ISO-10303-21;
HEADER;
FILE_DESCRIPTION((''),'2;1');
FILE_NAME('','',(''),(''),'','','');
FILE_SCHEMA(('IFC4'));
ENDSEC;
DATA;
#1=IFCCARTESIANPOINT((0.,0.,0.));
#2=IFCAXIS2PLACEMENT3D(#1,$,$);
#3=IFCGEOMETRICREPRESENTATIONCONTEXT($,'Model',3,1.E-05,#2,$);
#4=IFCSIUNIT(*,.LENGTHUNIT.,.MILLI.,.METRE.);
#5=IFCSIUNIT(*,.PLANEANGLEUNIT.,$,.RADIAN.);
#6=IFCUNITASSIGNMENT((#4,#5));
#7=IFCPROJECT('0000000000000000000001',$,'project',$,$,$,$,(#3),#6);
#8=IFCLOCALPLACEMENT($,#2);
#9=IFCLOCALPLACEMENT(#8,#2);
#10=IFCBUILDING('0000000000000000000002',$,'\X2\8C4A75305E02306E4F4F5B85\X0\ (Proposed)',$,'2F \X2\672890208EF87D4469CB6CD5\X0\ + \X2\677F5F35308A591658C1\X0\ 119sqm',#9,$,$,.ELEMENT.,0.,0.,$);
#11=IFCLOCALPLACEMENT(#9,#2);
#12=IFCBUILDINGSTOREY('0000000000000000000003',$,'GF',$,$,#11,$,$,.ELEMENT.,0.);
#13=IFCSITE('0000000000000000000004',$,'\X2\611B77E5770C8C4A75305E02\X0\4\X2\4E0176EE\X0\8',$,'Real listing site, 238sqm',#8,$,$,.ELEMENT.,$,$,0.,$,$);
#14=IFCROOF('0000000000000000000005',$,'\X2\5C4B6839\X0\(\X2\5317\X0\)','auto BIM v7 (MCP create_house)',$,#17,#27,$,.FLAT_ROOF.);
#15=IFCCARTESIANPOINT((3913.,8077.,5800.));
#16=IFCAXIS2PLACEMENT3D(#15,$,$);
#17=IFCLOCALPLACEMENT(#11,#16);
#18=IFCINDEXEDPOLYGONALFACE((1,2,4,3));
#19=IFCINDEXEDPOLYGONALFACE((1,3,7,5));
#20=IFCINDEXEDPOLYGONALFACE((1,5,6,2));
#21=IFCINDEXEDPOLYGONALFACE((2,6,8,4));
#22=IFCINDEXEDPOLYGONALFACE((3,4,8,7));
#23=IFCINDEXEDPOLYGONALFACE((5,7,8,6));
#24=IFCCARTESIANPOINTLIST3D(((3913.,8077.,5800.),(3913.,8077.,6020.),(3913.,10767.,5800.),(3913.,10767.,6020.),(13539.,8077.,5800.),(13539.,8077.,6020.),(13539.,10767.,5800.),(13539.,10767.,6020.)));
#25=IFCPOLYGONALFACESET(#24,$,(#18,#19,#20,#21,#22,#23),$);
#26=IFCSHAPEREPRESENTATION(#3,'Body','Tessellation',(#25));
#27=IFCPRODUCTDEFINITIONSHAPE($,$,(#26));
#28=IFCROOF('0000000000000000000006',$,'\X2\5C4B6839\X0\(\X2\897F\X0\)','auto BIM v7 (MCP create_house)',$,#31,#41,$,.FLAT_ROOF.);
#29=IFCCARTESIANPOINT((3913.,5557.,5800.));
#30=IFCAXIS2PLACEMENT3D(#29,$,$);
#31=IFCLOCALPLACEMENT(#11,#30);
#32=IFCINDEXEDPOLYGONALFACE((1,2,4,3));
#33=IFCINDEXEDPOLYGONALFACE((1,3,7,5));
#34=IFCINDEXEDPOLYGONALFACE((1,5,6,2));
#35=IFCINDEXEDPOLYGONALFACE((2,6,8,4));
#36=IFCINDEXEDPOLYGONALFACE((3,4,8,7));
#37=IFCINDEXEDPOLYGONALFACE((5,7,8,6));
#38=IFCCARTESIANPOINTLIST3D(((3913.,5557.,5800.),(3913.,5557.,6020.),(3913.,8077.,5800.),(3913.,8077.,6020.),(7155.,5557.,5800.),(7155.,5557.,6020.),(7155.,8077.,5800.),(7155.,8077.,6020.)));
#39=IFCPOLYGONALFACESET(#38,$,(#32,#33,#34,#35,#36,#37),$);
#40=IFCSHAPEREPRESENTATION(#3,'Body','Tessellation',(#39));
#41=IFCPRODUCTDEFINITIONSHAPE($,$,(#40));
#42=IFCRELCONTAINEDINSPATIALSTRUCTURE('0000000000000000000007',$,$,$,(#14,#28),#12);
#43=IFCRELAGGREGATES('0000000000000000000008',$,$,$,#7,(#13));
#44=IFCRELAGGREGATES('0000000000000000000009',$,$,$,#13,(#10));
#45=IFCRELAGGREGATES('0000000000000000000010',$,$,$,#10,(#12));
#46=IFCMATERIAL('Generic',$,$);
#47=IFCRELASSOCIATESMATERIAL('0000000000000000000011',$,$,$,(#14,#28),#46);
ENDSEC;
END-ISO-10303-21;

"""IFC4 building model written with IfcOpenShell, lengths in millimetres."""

from ifc_helpers import new_model, si_unit, frame, frame_2d, origin, place, context, project, spatial, rectangle, extrude, material, element, save


model = new_model("IFC4")

# Units and contexts
model_context = context("Model", 3, precision=1e-05, world=origin())
ifc_project = project(units=[si_unit("LENGTHUNIT", "METRE", prefix="MILLI"), si_unit("PLANEANGLEUNIT", "RADIAN")], contexts=[model_context])

# Site, building, storey
site_placement = place(None, origin())
site = spatial("IfcSite", under=ifc_project, at=site_placement, Name="愛知県豊田市4丁目8", ObjectType="Real listing site, 238sqm", CompositionType="ELEMENT", RefElevation=0.0)
building_placement = place(site_placement, origin())
building = spatial("IfcBuilding", under=site, at=building_placement, Name="豊田市の住宅 (Proposed)", ObjectType="2F 木造軸組構法 + 板張り外壁 119sqm", CompositionType="ELEMENT", ElevationOfRefHeight=0.0, ElevationOfTerrain=0.0)
storey_placement = place(building_placement, origin())
storey = spatial("IfcBuildingStorey", under=building, at=storey_placement, Name="GF", CompositionType="ELEMENT", Elevation=0.0)

# Shared definitions
ifc_material = material(Name="Generic")

# Roofs
roof_1_placement = place(storey_placement, frame((3913.0, 8077.0, 5800.0)))
element("IfcRoof", 1, at=roof_1_placement, inside=storey, material=ifc_material, Name="屋根(北)", Description="auto BIM v7 (MCP create_house)", PredefinedType="FLAT_ROOF", context=model_context, shape_type="SweptSolid", body=[
    extrude(rectangle(XDim=9626.0, YDim=2690.0, at=frame_2d((4813.0, 1345.0))), frame((3913.0, 8077.0, 5800.0)), (0.0, 0.0, 1.0), 220.0),
])
roof_2_placement = place(storey_placement, frame((3913.0, 5557.0, 5800.0)))
element("IfcRoof", 2, at=roof_2_placement, inside=storey, material=ifc_material, Name="屋根(西)", Description="auto BIM v7 (MCP create_house)", PredefinedType="FLAT_ROOF", context=model_context, shape_type="SweptSolid", body=[
    extrude(rectangle(XDim=3242.0, YDim=2520.0, at=frame_2d((1621.0, 1260.0))), frame((3913.0, 5557.0, 5800.0)), (0.0, 0.0, 1.0), 220.0),
])

save(model, "model.ifc")
